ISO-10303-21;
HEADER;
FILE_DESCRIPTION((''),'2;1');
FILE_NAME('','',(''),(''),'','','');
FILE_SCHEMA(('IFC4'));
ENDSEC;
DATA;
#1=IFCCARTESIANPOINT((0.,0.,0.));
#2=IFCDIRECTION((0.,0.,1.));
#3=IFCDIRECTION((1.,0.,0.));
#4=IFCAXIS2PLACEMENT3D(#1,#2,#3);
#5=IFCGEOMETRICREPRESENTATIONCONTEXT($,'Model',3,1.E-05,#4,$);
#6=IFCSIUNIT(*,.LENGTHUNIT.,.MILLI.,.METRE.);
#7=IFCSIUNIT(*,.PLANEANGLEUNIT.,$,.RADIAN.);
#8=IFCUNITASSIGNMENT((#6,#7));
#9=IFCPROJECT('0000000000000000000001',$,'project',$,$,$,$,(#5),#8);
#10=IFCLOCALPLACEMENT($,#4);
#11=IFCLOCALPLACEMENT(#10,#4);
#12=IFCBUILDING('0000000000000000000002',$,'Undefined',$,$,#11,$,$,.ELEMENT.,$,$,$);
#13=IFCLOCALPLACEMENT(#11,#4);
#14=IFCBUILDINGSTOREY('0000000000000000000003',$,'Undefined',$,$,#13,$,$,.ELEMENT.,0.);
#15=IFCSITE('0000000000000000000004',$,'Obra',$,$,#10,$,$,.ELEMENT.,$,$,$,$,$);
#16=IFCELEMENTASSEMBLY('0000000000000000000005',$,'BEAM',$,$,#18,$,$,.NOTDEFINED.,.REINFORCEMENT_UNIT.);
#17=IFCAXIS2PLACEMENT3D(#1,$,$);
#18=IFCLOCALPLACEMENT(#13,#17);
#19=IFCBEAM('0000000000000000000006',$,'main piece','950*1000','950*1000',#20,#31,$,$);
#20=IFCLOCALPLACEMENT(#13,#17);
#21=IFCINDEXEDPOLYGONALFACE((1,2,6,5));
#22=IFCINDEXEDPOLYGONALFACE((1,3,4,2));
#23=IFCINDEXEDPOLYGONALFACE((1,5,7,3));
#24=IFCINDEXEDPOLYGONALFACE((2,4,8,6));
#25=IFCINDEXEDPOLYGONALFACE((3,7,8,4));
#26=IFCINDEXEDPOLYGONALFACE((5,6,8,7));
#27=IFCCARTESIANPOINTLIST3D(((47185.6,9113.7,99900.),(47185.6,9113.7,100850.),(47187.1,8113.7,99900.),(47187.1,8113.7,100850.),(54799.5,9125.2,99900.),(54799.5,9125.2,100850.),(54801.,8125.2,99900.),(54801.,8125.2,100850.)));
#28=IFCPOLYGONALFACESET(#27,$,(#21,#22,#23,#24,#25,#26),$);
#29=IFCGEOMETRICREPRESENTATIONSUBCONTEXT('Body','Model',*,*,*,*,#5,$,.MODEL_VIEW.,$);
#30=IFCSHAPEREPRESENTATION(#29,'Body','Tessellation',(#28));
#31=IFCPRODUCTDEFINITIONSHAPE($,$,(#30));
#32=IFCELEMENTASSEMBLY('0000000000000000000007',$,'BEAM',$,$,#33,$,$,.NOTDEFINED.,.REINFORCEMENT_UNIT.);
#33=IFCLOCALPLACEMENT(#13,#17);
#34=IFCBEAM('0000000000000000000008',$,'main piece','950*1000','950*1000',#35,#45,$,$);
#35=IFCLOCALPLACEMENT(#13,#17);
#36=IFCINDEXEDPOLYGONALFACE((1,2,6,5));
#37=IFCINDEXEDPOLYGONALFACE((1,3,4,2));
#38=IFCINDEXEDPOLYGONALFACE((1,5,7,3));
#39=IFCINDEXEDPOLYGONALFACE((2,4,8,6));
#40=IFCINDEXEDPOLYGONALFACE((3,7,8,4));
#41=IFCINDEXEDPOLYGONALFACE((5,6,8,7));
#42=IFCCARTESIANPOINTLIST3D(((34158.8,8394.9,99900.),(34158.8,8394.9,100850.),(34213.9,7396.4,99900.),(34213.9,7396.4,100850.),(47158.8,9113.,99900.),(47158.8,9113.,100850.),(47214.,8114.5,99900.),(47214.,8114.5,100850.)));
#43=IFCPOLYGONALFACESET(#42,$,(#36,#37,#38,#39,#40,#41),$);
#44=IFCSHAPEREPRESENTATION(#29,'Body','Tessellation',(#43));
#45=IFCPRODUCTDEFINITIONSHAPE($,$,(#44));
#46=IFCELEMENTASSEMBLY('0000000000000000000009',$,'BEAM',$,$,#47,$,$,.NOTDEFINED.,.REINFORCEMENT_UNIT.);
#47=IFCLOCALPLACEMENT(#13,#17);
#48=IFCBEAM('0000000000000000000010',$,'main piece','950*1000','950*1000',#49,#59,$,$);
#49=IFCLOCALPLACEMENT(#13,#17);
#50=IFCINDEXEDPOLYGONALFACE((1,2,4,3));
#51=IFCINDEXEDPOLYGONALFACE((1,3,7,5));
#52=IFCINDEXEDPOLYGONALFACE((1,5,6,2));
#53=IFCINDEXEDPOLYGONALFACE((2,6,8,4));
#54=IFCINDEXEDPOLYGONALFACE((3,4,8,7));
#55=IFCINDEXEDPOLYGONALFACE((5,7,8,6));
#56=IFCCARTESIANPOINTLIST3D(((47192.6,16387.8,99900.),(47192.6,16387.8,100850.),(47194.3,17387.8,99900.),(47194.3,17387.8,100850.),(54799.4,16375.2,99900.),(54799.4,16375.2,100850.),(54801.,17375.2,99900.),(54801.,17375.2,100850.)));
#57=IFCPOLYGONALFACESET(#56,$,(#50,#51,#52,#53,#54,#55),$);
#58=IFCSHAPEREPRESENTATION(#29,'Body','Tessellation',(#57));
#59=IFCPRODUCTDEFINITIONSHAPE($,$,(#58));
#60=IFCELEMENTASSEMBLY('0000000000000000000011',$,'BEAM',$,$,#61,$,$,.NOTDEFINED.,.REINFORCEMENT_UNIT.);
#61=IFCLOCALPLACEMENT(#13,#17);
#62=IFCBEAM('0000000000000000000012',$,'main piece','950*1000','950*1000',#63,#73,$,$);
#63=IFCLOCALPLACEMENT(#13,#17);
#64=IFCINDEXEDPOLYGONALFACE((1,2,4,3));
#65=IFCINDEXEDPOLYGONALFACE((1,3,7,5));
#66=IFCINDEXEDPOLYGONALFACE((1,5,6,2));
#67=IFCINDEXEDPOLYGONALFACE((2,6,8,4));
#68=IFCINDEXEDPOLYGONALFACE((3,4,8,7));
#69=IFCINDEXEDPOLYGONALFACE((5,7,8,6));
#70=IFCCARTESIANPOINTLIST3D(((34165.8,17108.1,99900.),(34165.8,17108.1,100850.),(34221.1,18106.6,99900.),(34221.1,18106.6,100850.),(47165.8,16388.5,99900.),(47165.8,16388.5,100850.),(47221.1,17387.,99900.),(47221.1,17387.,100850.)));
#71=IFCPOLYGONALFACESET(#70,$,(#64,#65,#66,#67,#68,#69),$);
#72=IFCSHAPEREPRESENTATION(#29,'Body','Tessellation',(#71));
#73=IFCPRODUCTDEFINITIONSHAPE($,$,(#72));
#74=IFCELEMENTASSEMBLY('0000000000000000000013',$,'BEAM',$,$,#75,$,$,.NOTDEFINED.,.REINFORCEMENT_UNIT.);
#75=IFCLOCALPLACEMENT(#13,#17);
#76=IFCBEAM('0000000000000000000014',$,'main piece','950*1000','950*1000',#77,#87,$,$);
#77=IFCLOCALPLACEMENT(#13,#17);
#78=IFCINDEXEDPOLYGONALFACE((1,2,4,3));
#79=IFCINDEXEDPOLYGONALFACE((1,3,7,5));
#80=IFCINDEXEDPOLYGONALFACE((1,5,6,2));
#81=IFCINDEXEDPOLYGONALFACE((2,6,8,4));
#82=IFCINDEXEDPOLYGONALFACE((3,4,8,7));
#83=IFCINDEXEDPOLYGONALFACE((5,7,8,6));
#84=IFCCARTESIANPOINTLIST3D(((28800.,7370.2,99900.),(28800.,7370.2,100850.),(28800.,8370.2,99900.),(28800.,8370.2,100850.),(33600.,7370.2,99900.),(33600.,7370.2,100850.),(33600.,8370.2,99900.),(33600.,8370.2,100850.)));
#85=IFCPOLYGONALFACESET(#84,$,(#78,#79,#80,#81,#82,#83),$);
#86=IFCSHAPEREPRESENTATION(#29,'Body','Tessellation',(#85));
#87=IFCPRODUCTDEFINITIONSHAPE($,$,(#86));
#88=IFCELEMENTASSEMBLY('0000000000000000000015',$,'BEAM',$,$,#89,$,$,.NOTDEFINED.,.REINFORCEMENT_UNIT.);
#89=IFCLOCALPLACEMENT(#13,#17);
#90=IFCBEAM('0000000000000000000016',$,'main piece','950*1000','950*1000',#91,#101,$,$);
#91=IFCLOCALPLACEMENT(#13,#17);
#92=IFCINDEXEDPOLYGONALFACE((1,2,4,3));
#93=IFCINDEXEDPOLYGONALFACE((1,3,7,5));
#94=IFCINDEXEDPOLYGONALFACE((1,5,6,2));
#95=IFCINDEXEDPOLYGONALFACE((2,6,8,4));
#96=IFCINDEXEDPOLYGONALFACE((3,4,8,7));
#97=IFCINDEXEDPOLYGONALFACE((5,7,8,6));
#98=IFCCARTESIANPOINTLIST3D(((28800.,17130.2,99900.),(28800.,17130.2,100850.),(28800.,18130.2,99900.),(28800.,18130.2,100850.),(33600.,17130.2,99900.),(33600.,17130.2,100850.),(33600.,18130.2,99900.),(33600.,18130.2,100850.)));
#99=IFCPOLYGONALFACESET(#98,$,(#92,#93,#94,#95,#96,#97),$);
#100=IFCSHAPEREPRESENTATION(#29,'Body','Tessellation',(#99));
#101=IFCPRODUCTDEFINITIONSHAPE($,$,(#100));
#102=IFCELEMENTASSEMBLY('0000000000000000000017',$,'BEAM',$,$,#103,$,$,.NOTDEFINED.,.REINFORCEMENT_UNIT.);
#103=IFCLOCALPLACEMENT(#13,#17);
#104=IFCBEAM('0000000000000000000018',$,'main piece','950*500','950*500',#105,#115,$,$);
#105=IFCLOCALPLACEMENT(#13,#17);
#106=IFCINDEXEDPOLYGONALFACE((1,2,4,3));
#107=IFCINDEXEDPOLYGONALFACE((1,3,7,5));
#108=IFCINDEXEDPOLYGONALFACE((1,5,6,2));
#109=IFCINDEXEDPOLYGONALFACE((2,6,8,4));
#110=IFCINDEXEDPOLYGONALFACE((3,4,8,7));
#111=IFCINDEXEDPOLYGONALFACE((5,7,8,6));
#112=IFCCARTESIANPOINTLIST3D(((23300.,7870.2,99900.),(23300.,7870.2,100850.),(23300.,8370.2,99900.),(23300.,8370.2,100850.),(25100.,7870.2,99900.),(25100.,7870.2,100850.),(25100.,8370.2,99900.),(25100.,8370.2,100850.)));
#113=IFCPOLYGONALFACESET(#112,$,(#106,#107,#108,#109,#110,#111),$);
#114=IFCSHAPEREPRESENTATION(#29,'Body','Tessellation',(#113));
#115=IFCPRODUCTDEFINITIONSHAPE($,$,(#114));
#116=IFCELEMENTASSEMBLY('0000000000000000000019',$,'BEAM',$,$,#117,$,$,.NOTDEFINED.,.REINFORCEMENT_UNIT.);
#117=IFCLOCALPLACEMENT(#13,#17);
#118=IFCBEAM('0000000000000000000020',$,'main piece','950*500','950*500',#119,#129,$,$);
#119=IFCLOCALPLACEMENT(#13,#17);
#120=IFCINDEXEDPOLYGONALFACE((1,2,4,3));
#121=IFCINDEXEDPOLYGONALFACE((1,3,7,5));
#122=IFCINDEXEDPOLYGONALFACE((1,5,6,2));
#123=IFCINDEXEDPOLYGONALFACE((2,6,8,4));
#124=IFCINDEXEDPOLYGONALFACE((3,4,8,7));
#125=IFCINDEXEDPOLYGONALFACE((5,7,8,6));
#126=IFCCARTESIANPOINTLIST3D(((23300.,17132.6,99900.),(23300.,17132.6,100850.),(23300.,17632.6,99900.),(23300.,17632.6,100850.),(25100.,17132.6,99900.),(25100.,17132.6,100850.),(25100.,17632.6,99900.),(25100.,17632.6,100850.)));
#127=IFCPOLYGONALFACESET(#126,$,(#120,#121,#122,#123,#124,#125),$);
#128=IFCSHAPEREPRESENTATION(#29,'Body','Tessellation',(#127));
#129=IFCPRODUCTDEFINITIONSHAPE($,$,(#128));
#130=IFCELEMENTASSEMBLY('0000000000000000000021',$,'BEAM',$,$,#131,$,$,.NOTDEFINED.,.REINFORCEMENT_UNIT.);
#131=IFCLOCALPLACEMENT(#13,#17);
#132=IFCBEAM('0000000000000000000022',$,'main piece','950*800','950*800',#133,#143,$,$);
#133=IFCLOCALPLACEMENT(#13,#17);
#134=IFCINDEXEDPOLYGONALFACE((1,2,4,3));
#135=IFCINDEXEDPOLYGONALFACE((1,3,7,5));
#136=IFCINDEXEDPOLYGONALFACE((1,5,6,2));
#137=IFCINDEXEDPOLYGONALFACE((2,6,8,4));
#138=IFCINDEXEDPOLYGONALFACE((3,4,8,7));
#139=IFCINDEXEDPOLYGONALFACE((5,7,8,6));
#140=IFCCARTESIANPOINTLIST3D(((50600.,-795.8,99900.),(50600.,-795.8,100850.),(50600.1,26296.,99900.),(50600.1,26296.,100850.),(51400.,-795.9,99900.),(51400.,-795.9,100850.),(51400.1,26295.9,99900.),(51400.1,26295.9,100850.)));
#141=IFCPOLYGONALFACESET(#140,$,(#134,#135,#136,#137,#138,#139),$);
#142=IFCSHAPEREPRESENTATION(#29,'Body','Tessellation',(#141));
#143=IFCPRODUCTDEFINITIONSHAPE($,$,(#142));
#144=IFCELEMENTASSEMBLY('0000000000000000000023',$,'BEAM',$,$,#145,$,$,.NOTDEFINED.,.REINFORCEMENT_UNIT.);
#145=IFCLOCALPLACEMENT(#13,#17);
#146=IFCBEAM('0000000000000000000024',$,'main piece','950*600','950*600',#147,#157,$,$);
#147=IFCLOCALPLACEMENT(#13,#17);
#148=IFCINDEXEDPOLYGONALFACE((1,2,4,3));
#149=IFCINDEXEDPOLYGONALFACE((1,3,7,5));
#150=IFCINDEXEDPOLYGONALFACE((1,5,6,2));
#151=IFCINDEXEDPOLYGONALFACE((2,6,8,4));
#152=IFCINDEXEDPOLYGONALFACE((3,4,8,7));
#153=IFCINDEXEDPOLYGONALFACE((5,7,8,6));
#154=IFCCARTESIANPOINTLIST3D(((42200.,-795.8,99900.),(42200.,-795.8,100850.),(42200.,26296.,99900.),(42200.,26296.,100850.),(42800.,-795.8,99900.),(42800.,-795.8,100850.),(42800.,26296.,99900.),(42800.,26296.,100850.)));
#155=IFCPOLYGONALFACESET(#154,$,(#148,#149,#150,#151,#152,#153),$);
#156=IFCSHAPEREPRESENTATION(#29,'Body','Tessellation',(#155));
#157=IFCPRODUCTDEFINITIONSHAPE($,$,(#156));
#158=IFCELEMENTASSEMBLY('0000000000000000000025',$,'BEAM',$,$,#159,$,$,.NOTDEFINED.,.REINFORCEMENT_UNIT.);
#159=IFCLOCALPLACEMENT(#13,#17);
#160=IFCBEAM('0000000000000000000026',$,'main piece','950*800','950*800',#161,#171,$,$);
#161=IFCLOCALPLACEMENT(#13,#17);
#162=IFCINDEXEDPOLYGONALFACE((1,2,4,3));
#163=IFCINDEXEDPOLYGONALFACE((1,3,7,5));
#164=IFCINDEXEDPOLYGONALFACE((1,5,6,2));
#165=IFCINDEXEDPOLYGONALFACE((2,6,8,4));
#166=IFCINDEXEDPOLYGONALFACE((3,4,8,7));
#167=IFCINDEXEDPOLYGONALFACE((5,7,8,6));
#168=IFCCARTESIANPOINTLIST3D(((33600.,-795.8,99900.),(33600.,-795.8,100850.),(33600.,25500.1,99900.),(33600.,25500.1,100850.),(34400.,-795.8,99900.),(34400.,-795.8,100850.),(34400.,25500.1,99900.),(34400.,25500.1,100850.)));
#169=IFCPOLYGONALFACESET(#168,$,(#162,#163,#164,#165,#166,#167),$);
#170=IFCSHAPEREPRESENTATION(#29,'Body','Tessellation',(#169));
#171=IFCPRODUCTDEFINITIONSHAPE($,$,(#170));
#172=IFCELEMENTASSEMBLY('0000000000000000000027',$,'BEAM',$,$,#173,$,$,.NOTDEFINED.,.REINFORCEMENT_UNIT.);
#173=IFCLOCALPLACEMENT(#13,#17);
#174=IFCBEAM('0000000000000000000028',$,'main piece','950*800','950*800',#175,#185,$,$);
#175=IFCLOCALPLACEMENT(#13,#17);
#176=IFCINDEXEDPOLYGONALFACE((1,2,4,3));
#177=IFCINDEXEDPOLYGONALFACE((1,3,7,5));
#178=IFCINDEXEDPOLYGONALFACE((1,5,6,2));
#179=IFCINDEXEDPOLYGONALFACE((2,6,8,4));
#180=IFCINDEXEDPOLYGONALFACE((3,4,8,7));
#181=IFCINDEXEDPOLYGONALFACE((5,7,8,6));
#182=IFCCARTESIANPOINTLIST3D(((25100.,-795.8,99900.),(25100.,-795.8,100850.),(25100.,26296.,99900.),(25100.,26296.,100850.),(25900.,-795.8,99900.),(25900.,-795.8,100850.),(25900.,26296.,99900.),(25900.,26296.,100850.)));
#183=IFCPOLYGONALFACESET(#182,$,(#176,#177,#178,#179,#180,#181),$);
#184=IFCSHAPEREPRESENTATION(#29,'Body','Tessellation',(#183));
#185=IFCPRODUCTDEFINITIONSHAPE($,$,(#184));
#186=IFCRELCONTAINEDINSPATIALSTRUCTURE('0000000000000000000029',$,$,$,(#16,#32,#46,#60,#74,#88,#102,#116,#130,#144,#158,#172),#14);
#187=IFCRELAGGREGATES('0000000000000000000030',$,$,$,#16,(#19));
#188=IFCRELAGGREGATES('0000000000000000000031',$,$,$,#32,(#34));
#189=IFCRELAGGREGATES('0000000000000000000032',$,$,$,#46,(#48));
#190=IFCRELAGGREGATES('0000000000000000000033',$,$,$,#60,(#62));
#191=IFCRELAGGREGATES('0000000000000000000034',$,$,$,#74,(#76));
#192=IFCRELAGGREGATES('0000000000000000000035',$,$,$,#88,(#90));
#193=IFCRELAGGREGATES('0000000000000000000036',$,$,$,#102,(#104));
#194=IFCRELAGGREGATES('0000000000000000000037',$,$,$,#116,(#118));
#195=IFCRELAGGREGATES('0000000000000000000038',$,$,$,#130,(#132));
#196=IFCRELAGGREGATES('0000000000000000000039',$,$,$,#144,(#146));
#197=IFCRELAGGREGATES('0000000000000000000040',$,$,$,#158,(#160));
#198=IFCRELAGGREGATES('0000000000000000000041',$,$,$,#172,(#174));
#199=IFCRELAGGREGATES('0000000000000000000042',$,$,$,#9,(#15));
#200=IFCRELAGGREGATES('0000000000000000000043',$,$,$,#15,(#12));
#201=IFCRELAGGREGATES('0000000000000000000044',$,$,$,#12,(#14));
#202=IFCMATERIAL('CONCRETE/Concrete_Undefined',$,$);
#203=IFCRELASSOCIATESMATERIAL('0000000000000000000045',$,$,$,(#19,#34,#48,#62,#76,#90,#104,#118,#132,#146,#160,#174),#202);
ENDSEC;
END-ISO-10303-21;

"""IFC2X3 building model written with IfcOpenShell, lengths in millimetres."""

from ifc_helpers import new_model, si_unit, frame, origin_with_axes, origin_2d_with_axis, place, context, subcontext, project, spatial, rectangle, extrude, material, element, aggregate, save


model = new_model("IFC2X3")

# Units and contexts
model_context = context("Model", 3, precision=1e-05, world=origin_with_axes())
body_context = subcontext(model_context, "Body", "Model", "MODEL_VIEW")
ifc_project = project(units=[si_unit("LENGTHUNIT", "METRE", prefix="MILLI"), si_unit("PLANEANGLEUNIT", "RADIAN")], contexts=[model_context])

# Site, building, storey
site_placement = place(None, origin_with_axes())
site = spatial("IfcSite", under=ifc_project, at=site_placement, Name="Obra", CompositionType="ELEMENT")
building_placement = place(site_placement, origin_with_axes())
building = spatial("IfcBuilding", under=site, at=building_placement, Name="Undefined", CompositionType="ELEMENT")
storey_placement = place(building_placement, origin_with_axes())
storey = spatial("IfcBuildingStorey", under=building, at=storey_placement, Name="Undefined", CompositionType="ELEMENT", Elevation=0.0)

# Element assemblies, beams
assembly_1_placement = place(storey_placement, origin_with_axes())
assembly_1 = element("IfcElementAssembly", 1, at=assembly_1_placement, inside=storey, Name="BEAM", AssemblyPlace="NOTDEFINED", PredefinedType="REINFORCEMENT_UNIT")
ifc_material_1 = material(Name="CONCRETE/Concrete_Undefined")
beam_1_placement = place(assembly_1_placement, frame((47186.4, 8613.7, 100375.0), z_axis=(0.0, 0.0, 1.0), x_axis=(0.999999, 0.001508, 0.0)))
beam_1 = element("IfcBeam", 2, at=beam_1_placement, material=ifc_material_1, Name="main piece", Description="950*1000", ObjectType="950*1000", context=body_context, shape_type="SweptSolid", body=[
    extrude(rectangle(XDim=1000.0, YDim=950.0, at=origin_2d_with_axis()), frame((7613.8, 0.0, 0.0), z_axis=(-1.0, 0.0, 0.0), x_axis=(0.0, -1.0, 0.0)), (0.0, 0.0, 1.0), 7613.8),
])
aggregate(assembly_1, [beam_1])
assembly_2_placement = place(storey_placement, origin_with_axes())
assembly_2 = element("IfcElementAssembly", 3, at=assembly_2_placement, inside=storey, Name="BEAM", AssemblyPlace="NOTDEFINED", PredefinedType="REINFORCEMENT_UNIT")
beam_2_placement = place(assembly_2_placement, frame((34186.4, 7895.7, 100375.0), z_axis=(0.0, 0.0, 1.0), x_axis=(0.998478, 0.055152, 0.0)))
beam_2 = element("IfcBeam", 4, at=beam_2_placement, material=ifc_material_1, Name="main piece", Description="950*1000", ObjectType="950*1000", context=body_context, shape_type="SweptSolid", body=[
    extrude(rectangle(XDim=1000.0, YDim=950.0, at=origin_2d_with_axis()), frame((13019.8, 0.0, 0.0), z_axis=(-1.0, 0.0, 0.0), x_axis=(0.0, -1.0, 0.0)), (0.0, 0.0, 1.0), 13019.8),
])
aggregate(assembly_2, [beam_2])
assembly_3_placement = place(storey_placement, origin_with_axes())
assembly_3 = element("IfcElementAssembly", 5, at=assembly_3_placement, inside=storey, Name="BEAM", AssemblyPlace="NOTDEFINED", PredefinedType="REINFORCEMENT_UNIT")
beam_3_placement = place(assembly_3_placement, frame((47193.5, 16887.8, 100375.0), z_axis=(0.0, 0.0, 1.0), x_axis=(0.999999, -0.001649, 0.0)))
beam_3 = element("IfcBeam", 6, at=beam_3_placement, material=ifc_material_1, Name="main piece", Description="950*1000", ObjectType="950*1000", context=body_context, shape_type="SweptSolid", body=[
    extrude(rectangle(XDim=1000.0, YDim=950.0, at=origin_2d_with_axis()), frame((7606.8, 0.0, 0.0), z_axis=(-1.0, 0.0, 0.0), x_axis=(0.0, -1.0, 0.0)), (0.0, 0.0, 1.0), 7606.8),
])
aggregate(assembly_3, [beam_3])
assembly_4_placement = place(storey_placement, origin_with_axes())
assembly_4 = element("IfcElementAssembly", 7, at=assembly_4_placement, inside=storey, Name="BEAM", AssemblyPlace="NOTDEFINED", PredefinedType="REINFORCEMENT_UNIT")
beam_4_placement = place(assembly_4_placement, frame((34193.5, 17607.3, 100375.0), z_axis=(0.0, 0.0, 1.0), x_axis=(0.998472, -0.055268, 0.0)))
beam_4 = element("IfcBeam", 8, at=beam_4_placement, material=ifc_material_1, Name="main piece", Description="950*1000", ObjectType="950*1000", context=body_context, shape_type="SweptSolid", body=[
    extrude(rectangle(XDim=1000.0, YDim=950.0, at=origin_2d_with_axis()), frame((13019.9, 0.0, 0.0), z_axis=(-1.0, 0.0, 0.0), x_axis=(0.0, -1.0, 0.0)), (0.0, 0.0, 1.0), 13019.9),
])
aggregate(assembly_4, [beam_4])
assembly_5_placement = place(storey_placement, origin_with_axes())
assembly_5 = element("IfcElementAssembly", 9, at=assembly_5_placement, inside=storey, Name="BEAM", AssemblyPlace="NOTDEFINED", PredefinedType="REINFORCEMENT_UNIT")
beam_5_placement = place(assembly_5_placement, frame((28800.0, 7870.2, 100375.0), z_axis=(0.0, 0.0, 1.0), x_axis=(1.0, 0.000005, 0.0)))
beam_5 = element("IfcBeam", 10, at=beam_5_placement, material=ifc_material_1, Name="main piece", Description="950*1000", ObjectType="950*1000", context=body_context, shape_type="SweptSolid", body=[
    extrude(rectangle(XDim=1000.0, YDim=950.0, at=origin_2d_with_axis()), frame((4800.0, 0.0, 0.0), z_axis=(-1.0, 0.0, 0.0), x_axis=(0.0, -1.0, 0.0)), (0.0, 0.0, 1.0), 4800.0),
])
aggregate(assembly_5, [beam_5])
assembly_6_placement = place(storey_placement, origin_with_axes())
assembly_6 = element("IfcElementAssembly", 11, at=assembly_6_placement, inside=storey, Name="BEAM", AssemblyPlace="NOTDEFINED", PredefinedType="REINFORCEMENT_UNIT")
beam_6_placement = place(assembly_6_placement, frame((28800.0, 17630.2, 100375.0), z_axis=(0.0, 0.0, 1.0), x_axis=(1.0, 0.000001, 0.0)))
beam_6 = element("IfcBeam", 12, at=beam_6_placement, material=ifc_material_1, Name="main piece", Description="950*1000", ObjectType="950*1000", context=body_context, shape_type="SweptSolid", body=[
    extrude(rectangle(XDim=1000.0, YDim=950.0, at=origin_2d_with_axis()), frame((4800.0, 0.0, 0.0), z_axis=(-1.0, 0.0, 0.0), x_axis=(0.0, -1.0, 0.0)), (0.0, 0.0, 1.0), 4800.0),
])
aggregate(assembly_6, [beam_6])
assembly_7_placement = place(storey_placement, origin_with_axes())
assembly_7 = element("IfcElementAssembly", 13, at=assembly_7_placement, inside=storey, Name="BEAM", AssemblyPlace="NOTDEFINED", PredefinedType="REINFORCEMENT_UNIT")
beam_7_placement = place(assembly_7_placement, frame((25100.0, 8120.2, 100375.0), z_axis=(0.0, 0.0, 1.0), x_axis=(-1.0, 0.0, 0.0)))
beam_7 = element("IfcBeam", 14, at=beam_7_placement, material=ifc_material_1, Name="main piece", Description="950*500", ObjectType="950*500", context=body_context, shape_type="SweptSolid", body=[
    extrude(rectangle(XDim=500.0, YDim=950.0, at=origin_2d_with_axis()), frame((1800.0, 0.0, 0.0), z_axis=(-1.0, 0.0, 0.0), x_axis=(0.0, -1.0, 0.0)), (0.0, 0.0, 1.0), 1800.0),
])
aggregate(assembly_7, [beam_7])
assembly_8_placement = place(storey_placement, origin_with_axes())
assembly_8 = element("IfcElementAssembly", 15, at=assembly_8_placement, inside=storey, Name="BEAM", AssemblyPlace="NOTDEFINED", PredefinedType="REINFORCEMENT_UNIT")
beam_8_placement = place(assembly_8_placement, frame((25100.0, 17382.6, 100375.0), z_axis=(0.0, 0.0, 1.0), x_axis=(-1.0, 0.0, 0.0)))
beam_8 = element("IfcBeam", 16, at=beam_8_placement, material=ifc_material_1, Name="main piece", Description="950*500", ObjectType="950*500", context=body_context, shape_type="SweptSolid", body=[
    extrude(rectangle(XDim=500.0, YDim=950.0, at=origin_2d_with_axis()), frame((1800.0, 0.0, 0.0), z_axis=(-1.0, 0.0, 0.0), x_axis=(0.0, -1.0, 0.0)), (0.0, 0.0, 1.0), 1800.0),
])
aggregate(assembly_8, [beam_8])
assembly_9_placement = place(storey_placement, origin_with_axes())
assembly_9 = element("IfcElementAssembly", 17, at=assembly_9_placement, inside=storey, Name="BEAM", AssemblyPlace="NOTDEFINED", PredefinedType="REINFORCEMENT_UNIT")
beam_9_placement = place(assembly_9_placement, frame((51000.0, -795.8, 100375.0), z_axis=(0.0, 0.0, 1.0), x_axis=(0.000003, 1.0, 0.0)))
beam_9 = element("IfcBeam", 18, at=beam_9_placement, material=ifc_material_1, Name="main piece", Description="950*800", ObjectType="950*800", context=body_context, shape_type="SweptSolid", body=[
    extrude(rectangle(XDim=800.0, YDim=950.0, at=origin_2d_with_axis()), frame((27091.8, 0.0, 0.0), z_axis=(-1.0, 0.0, 0.0), x_axis=(0.0, -1.0, 0.0)), (0.0, 0.0, 1.0), 27091.8),
])
aggregate(assembly_9, [beam_9])
assembly_10_placement = place(storey_placement, origin_with_axes())
assembly_10 = element("IfcElementAssembly", 19, at=assembly_10_placement, inside=storey, Name="BEAM", AssemblyPlace="NOTDEFINED", PredefinedType="REINFORCEMENT_UNIT")
beam_10_placement = place(assembly_10_placement, frame((42500.0, -795.8, 100375.0), z_axis=(0.0, 0.0, 1.0), x_axis=(0.0, 1.0, 0.0)))
beam_10 = element("IfcBeam", 20, at=beam_10_placement, material=ifc_material_1, Name="main piece", Description="950*600", ObjectType="950*600", context=body_context, shape_type="SweptSolid", body=[
    extrude(rectangle(XDim=600.0, YDim=950.0, at=origin_2d_with_axis()), frame((27091.8, 0.0, 0.0), z_axis=(-1.0, 0.0, 0.0), x_axis=(0.0, -1.0, 0.0)), (0.0, 0.0, 1.0), 27091.8),
])
aggregate(assembly_10, [beam_10])
assembly_11_placement = place(storey_placement, origin_with_axes())
assembly_11 = element("IfcElementAssembly", 21, at=assembly_11_placement, inside=storey, Name="BEAM", AssemblyPlace="NOTDEFINED", PredefinedType="REINFORCEMENT_UNIT")
beam_11_placement = place(assembly_11_placement, frame((34000.0, -795.8, 100375.0), z_axis=(0.0, 0.0, 1.0), x_axis=(0.0, 1.0, 0.0)))
beam_11 = element("IfcBeam", 22, at=beam_11_placement, material=ifc_material_1, Name="main piece", Description="950*800", ObjectType="950*800", context=body_context, shape_type="SweptSolid", body=[
    extrude(rectangle(XDim=800.0, YDim=950.0, at=origin_2d_with_axis()), frame((26296.0, 0.0, 0.0), z_axis=(-1.0, 0.0, 0.0), x_axis=(0.0, -1.0, 0.0)), (0.0, 0.0, 1.0), 26296.0),
])
aggregate(assembly_11, [beam_11])
assembly_12_placement = place(storey_placement, origin_with_axes())
assembly_12 = element("IfcElementAssembly", 23, at=assembly_12_placement, inside=storey, Name="BEAM", AssemblyPlace="NOTDEFINED", PredefinedType="REINFORCEMENT_UNIT")
beam_12_placement = place(assembly_12_placement, frame((25500.0, -795.8, 100375.0), z_axis=(0.0, 0.0, 1.0), x_axis=(0.0, 1.0, 0.0)))
beam_12 = element("IfcBeam", 24, at=beam_12_placement, material=ifc_material_1, Name="main piece", Description="950*800", ObjectType="950*800", context=body_context, shape_type="SweptSolid", body=[
    extrude(rectangle(XDim=800.0, YDim=950.0, at=origin_2d_with_axis()), frame((27091.8, 0.0, 0.0), z_axis=(-1.0, 0.0, 0.0), x_axis=(0.0, -1.0, 0.0)), (0.0, 0.0, 1.0), 27091.8),
])
aggregate(assembly_12, [beam_12])

save(model, "model.ifc")
